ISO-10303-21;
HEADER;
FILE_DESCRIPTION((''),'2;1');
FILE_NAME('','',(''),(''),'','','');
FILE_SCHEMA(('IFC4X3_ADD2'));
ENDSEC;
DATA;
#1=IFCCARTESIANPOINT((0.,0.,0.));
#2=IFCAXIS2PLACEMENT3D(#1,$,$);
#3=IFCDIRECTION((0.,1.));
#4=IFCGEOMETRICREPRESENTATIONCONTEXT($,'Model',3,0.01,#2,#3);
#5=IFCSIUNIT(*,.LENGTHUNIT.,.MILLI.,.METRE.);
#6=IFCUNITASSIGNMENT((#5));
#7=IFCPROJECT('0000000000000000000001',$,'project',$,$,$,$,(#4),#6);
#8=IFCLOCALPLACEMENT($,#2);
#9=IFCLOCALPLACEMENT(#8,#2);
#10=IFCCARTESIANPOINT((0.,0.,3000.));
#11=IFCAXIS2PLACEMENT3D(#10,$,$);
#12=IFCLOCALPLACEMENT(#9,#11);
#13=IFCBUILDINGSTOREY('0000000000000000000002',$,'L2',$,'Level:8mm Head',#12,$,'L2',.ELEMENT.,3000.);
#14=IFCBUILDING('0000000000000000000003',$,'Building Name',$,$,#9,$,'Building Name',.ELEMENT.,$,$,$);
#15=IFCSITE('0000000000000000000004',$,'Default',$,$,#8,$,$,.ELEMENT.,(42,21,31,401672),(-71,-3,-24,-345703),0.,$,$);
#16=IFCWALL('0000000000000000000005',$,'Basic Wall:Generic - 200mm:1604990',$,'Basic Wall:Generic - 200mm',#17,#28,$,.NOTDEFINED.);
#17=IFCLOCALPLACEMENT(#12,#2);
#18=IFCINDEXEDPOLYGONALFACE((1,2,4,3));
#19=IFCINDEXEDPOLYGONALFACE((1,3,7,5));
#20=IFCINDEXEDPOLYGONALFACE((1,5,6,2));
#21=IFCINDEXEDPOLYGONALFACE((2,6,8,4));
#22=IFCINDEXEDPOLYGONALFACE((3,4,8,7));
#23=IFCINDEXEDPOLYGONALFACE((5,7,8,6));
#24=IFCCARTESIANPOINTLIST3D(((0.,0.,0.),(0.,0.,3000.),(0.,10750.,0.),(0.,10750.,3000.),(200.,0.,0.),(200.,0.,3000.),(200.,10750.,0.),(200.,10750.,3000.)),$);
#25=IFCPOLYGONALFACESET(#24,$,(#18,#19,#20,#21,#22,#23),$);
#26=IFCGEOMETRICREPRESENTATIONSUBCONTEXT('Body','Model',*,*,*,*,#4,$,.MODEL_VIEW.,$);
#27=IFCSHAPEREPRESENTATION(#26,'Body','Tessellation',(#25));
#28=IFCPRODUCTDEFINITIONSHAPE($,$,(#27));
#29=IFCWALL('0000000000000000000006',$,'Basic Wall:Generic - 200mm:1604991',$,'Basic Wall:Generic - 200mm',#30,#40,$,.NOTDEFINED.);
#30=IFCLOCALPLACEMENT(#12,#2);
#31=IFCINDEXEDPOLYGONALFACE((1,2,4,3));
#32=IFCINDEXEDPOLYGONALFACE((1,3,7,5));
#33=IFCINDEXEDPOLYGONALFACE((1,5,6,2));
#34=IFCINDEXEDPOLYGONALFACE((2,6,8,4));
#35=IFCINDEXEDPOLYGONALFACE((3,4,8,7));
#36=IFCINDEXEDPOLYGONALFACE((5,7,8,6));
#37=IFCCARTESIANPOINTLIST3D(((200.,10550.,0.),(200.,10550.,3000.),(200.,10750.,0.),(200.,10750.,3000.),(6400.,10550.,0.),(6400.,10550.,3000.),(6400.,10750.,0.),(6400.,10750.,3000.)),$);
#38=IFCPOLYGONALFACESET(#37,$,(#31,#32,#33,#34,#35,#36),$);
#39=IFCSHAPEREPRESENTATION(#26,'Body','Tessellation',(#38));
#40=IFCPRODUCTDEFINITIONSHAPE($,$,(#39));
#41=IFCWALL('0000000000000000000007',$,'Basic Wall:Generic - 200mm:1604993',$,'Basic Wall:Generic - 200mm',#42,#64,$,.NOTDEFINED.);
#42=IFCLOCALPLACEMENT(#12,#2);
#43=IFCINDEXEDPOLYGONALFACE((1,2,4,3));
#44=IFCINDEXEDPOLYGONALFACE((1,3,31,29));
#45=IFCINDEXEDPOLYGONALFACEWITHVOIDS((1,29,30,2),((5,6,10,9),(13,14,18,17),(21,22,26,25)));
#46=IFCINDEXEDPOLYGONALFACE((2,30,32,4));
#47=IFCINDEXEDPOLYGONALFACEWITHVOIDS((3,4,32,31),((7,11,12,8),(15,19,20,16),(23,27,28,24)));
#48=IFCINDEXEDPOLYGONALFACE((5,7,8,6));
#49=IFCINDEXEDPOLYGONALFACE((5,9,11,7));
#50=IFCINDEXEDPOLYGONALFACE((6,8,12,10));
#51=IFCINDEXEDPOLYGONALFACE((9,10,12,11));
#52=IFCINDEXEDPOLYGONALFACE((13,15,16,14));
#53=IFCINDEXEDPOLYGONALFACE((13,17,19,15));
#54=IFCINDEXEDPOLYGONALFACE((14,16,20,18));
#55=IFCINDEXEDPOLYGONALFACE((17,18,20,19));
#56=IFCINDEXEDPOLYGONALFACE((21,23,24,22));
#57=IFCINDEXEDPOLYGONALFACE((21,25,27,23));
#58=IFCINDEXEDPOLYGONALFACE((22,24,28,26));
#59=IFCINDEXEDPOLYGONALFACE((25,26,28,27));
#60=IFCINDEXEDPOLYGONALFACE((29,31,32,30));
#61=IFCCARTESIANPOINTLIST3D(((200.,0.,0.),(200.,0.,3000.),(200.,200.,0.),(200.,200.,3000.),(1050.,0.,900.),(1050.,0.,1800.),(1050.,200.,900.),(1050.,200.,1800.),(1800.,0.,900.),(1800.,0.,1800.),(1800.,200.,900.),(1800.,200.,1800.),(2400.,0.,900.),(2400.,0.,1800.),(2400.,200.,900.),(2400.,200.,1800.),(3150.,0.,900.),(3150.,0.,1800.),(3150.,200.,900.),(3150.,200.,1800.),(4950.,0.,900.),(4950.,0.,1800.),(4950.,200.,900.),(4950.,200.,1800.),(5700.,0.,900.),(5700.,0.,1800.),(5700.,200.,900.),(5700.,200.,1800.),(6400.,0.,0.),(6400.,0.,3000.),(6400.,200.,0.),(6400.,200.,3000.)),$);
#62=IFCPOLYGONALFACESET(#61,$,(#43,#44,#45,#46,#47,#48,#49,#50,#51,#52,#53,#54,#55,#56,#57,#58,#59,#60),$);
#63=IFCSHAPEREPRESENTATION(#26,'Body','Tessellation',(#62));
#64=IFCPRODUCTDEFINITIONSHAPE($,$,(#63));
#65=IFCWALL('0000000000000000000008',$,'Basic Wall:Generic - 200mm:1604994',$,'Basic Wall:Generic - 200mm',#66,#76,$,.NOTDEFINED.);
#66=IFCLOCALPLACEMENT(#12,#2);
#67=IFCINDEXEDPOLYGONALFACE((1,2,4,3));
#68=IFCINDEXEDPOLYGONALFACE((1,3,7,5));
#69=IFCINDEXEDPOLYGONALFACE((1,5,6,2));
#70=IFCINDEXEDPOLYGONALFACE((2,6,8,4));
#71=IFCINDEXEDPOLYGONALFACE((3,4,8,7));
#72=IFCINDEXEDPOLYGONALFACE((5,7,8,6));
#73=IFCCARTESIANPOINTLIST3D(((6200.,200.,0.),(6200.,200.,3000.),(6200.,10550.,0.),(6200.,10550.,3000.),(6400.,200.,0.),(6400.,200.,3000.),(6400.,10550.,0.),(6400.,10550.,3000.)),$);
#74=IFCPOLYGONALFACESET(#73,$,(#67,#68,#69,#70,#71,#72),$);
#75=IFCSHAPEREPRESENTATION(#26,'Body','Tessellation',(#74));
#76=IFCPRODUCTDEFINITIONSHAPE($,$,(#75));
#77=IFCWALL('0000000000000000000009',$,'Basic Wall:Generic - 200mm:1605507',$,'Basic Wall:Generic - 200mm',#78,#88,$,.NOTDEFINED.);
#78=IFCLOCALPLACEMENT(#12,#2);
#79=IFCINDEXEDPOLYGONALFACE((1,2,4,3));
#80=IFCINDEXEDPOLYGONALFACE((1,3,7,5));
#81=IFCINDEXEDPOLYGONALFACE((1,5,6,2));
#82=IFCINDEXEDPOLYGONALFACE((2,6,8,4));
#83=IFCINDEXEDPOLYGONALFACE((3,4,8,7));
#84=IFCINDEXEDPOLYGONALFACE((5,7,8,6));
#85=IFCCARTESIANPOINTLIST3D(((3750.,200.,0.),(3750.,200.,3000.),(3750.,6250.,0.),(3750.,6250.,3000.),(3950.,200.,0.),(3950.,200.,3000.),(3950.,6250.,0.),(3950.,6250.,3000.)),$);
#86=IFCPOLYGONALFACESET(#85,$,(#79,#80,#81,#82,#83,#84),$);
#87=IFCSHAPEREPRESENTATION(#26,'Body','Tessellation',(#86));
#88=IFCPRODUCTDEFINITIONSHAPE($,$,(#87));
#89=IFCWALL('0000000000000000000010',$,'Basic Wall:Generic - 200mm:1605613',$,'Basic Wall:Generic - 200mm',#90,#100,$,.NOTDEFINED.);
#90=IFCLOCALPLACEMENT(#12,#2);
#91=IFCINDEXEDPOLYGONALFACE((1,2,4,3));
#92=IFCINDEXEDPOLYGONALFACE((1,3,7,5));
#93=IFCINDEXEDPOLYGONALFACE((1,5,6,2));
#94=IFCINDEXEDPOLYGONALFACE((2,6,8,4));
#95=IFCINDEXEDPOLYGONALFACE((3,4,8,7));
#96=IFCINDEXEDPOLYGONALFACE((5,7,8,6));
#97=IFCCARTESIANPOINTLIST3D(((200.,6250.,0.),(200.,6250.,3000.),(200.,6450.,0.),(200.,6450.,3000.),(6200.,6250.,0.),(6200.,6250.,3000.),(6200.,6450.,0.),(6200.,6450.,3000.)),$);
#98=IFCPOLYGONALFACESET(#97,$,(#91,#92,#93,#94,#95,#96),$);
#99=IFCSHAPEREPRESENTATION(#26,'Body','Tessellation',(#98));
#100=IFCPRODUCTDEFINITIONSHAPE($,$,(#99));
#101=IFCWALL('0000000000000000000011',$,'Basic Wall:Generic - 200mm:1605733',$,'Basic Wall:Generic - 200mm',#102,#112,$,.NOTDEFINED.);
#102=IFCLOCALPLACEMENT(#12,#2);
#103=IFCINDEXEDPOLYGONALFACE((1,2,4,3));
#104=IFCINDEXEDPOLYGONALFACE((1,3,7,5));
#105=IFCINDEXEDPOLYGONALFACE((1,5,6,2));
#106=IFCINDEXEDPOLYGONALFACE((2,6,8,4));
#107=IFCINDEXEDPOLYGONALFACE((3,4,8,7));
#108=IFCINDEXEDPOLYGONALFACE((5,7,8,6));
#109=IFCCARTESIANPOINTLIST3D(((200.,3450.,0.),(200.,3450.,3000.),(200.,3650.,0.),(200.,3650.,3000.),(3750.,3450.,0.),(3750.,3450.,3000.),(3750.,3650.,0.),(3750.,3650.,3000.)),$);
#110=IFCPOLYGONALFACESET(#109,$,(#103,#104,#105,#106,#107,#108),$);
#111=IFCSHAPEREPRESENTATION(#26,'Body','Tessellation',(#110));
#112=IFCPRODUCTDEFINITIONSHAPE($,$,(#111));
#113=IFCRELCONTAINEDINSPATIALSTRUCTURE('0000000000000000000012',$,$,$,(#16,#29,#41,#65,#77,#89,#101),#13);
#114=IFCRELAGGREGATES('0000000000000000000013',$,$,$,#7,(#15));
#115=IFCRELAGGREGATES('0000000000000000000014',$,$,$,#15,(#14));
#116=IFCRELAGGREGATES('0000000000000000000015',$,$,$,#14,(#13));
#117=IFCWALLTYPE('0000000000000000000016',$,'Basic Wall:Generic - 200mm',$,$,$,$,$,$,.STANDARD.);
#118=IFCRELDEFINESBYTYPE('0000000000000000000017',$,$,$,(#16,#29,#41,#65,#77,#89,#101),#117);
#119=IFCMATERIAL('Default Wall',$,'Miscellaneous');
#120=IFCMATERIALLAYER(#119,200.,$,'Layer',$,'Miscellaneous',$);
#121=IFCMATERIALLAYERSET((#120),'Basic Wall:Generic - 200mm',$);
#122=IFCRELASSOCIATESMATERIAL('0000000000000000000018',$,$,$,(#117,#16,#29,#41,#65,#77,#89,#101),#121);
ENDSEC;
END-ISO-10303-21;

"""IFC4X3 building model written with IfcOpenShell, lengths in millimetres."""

from ifc_helpers import new_model, si_unit, direction, frame, frame_2d, origin, place, context, subcontext, project, spatial, rectangle, extrude, material, layer, layer_set, type_object, element, save


model = new_model("IFC4X3")

# Units and contexts
model_context = context("Model", 3, precision=0.01, world=origin(), true_north=direction((0.0, 1.0)))
body_context = subcontext(model_context, "Body", "Model", "MODEL_VIEW")
ifc_project = project(units=[si_unit("LENGTHUNIT", "METRE", prefix="MILLI")], contexts=[model_context])

# Site, building, storey
site_placement = place(None, origin())
site = spatial("IfcSite", under=ifc_project, at=site_placement, Name="Default", CompositionType="ELEMENT", RefLatitude=(42, 21, 31, 401672), RefLongitude=(-71, -3, -24, -345703), RefElevation=0.0)
building_placement = place(site_placement, origin())
building = spatial("IfcBuilding", under=site, at=building_placement, Name="Building Name", LongName="Building Name", CompositionType="ELEMENT")
storey_placement = place(building_placement, frame((0.0, 0.0, 3000.0)))
storey = spatial("IfcBuildingStorey", under=building, at=storey_placement, Name="L2", ObjectType="Level:8mm Head", LongName="L2", CompositionType="ELEMENT", Elevation=3000.0)

# Walls
ifc_material = material(Name="Default Wall", Category="Miscellaneous")
ifc_layer = layer(ifc_material, 200.0, Name="Layer", Category="Miscellaneous")
ifc_layer_set = layer_set([ifc_layer], Name="Basic Wall:Generic - 200mm")
wall_type = type_object("IfcWallType", Name="Basic Wall:Generic - 200mm", PredefinedType="STANDARD", material=ifc_layer_set)
wall_1_placement = place(storey_placement, frame((100.0, 0.0, 0.0), z_axis=(0.0, 0.0, 1.0), x_axis=(0.0, 1.0, 0.0)))
element("IfcWall", 1, at=wall_1_placement, inside=storey, type_object=wall_type, material=ifc_layer_set, Name="Basic Wall:Generic - 200mm:1604990", ObjectType="Basic Wall:Generic - 200mm", PredefinedType="NOTDEFINED", context=body_context, shape_type="SweptSolid", body=[
    extrude(rectangle(XDim=10750.0, YDim=200.0, at=frame_2d((5375.0, 0.0), x_axis=(-1.0, 0.0))), origin(), (0.0, 0.0, 1.0), 3000.0),
])
wall_2_placement = place(storey_placement, frame((200.0, 10650.0, 0.0)))
element("IfcWall", 2, at=wall_2_placement, inside=storey, type_object=wall_type, material=ifc_layer_set, Name="Basic Wall:Generic - 200mm:1604991", ObjectType="Basic Wall:Generic - 200mm", PredefinedType="NOTDEFINED", context=body_context, shape_type="SweptSolid", body=[
    extrude(rectangle(XDim=6200.0, YDim=200.0, at=frame_2d((3100.0, 0.0), x_axis=(-1.0, 0.0))), origin(), (0.0, 0.0, 1.0), 3000.0),
])

# Wall, openings
wall_3_placement = place(storey_placement, frame((6400.0, 100.0, 0.0), z_axis=(0.0, 0.0, 1.0), x_axis=(-1.0, 0.0, 0.0)))
wall_3 = element("IfcWall", 3, at=wall_3_placement, inside=storey, type_object=wall_type, material=ifc_layer_set, Name="Basic Wall:Generic - 200mm:1604993", ObjectType="Basic Wall:Generic - 200mm", PredefinedType="NOTDEFINED", context=body_context, shape_type="SweptSolid", body=[
    extrude(rectangle(XDim=6200.0, YDim=200.0, at=frame_2d((3100.0, 0.0), x_axis=(-1.0, 0.0))), origin(), (0.0, 0.0, 1.0), 3000.0),
])
opening_1_placement = place(wall_3_placement, frame((4600.0, -100.0, 900.0)))
element("IfcOpeningElement", 4, at=opening_1_placement, cuts=wall_3, PredefinedType="OPENING", context=body_context, shape_type="SweptSolid", body=[
    extrude(rectangle(XDim=900.0, YDim=750.0, at=frame_2d((450.0, 375.0), x_axis=(-1.0, 0.0))), frame((0.0, 0.0, 0.0), z_axis=(0.0, 1.0, 0.0), x_axis=(0.0, 0.0, 1.0)), (0.0, 0.0, 1.0), 200.0),
])
opening_2_placement = place(wall_3_placement, frame((3250.0, -100.0, 900.0)))
element("IfcOpeningElement", 5, at=opening_2_placement, cuts=wall_3, PredefinedType="OPENING", context=body_context, shape_type="SweptSolid", body=[
    extrude(rectangle(XDim=900.0, YDim=750.0, at=frame_2d((450.0, 375.0), x_axis=(-1.0, 0.0))), frame((0.0, 0.0, 0.0), z_axis=(0.0, 1.0, 0.0), x_axis=(0.0, 0.0, 1.0)), (0.0, 0.0, 1.0), 200.0),
])
opening_3_placement = place(wall_3_placement, frame((700.0, -100.0, 900.0)))
element("IfcOpeningElement", 6, at=opening_3_placement, cuts=wall_3, PredefinedType="OPENING", context=body_context, shape_type="SweptSolid", body=[
    extrude(rectangle(XDim=900.0, YDim=750.0, at=frame_2d((450.0, 375.0), x_axis=(-1.0, 0.0))), frame((0.0, 0.0, 0.0), z_axis=(0.0, 1.0, 0.0), x_axis=(0.0, 0.0, 1.0)), (0.0, 0.0, 1.0), 200.0),
])

# Walls
wall_4_placement = place(storey_placement, frame((6300.0, 200.0, 0.0), z_axis=(0.0, 0.0, 1.0), x_axis=(0.0, 1.0, 0.0)))
element("IfcWall", 7, at=wall_4_placement, inside=storey, type_object=wall_type, material=ifc_layer_set, Name="Basic Wall:Generic - 200mm:1604994", ObjectType="Basic Wall:Generic - 200mm", PredefinedType="NOTDEFINED", context=body_context, shape_type="SweptSolid", body=[
    extrude(rectangle(XDim=10350.0, YDim=200.0, at=frame_2d((5175.0, 0.0), x_axis=(-1.0, 0.0))), origin(), (0.0, 0.0, 1.0), 3000.0),
])
wall_5_placement = place(storey_placement, frame((3850.0, 200.0, 0.0), z_axis=(0.0, 0.0, 1.0), x_axis=(0.0, 1.0, 0.0)))
element("IfcWall", 8, at=wall_5_placement, inside=storey, type_object=wall_type, material=ifc_layer_set, Name="Basic Wall:Generic - 200mm:1605507", ObjectType="Basic Wall:Generic - 200mm", PredefinedType="NOTDEFINED", context=body_context, shape_type="SweptSolid", body=[
    extrude(rectangle(XDim=6050.0, YDim=200.0, at=frame_2d((3025.0, 0.0), x_axis=(-1.0, 0.0))), origin(), (0.0, 0.0, 1.0), 3000.0),
])
wall_6_placement = place(storey_placement, frame((6200.0, 6350.0, 0.0), z_axis=(0.0, 0.0, 1.0), x_axis=(-1.0, 0.0, 0.0)))
element("IfcWall", 9, at=wall_6_placement, inside=storey, type_object=wall_type, material=ifc_layer_set, Name="Basic Wall:Generic - 200mm:1605613", ObjectType="Basic Wall:Generic - 200mm", PredefinedType="NOTDEFINED", context=body_context, shape_type="SweptSolid", body=[
    extrude(rectangle(XDim=6000.0, YDim=200.0, at=frame_2d((3000.0, 0.0), x_axis=(-1.0, 0.0))), origin(), (0.0, 0.0, 1.0), 3000.0),
])
wall_7_placement = place(storey_placement, frame((3750.0, 3550.0, 0.0), z_axis=(0.0, 0.0, 1.0), x_axis=(-1.0, 0.0, 0.0)))
element("IfcWall", 10, at=wall_7_placement, inside=storey, type_object=wall_type, material=ifc_layer_set, Name="Basic Wall:Generic - 200mm:1605733", ObjectType="Basic Wall:Generic - 200mm", PredefinedType="NOTDEFINED", context=body_context, shape_type="SweptSolid", body=[
    extrude(rectangle(XDim=3550.0, YDim=200.0, at=frame_2d((1775.0, 0.0), x_axis=(-1.0, 0.0))), origin(), (0.0, 0.0, 1.0), 3000.0),
])

save(model, "model.ifc")
